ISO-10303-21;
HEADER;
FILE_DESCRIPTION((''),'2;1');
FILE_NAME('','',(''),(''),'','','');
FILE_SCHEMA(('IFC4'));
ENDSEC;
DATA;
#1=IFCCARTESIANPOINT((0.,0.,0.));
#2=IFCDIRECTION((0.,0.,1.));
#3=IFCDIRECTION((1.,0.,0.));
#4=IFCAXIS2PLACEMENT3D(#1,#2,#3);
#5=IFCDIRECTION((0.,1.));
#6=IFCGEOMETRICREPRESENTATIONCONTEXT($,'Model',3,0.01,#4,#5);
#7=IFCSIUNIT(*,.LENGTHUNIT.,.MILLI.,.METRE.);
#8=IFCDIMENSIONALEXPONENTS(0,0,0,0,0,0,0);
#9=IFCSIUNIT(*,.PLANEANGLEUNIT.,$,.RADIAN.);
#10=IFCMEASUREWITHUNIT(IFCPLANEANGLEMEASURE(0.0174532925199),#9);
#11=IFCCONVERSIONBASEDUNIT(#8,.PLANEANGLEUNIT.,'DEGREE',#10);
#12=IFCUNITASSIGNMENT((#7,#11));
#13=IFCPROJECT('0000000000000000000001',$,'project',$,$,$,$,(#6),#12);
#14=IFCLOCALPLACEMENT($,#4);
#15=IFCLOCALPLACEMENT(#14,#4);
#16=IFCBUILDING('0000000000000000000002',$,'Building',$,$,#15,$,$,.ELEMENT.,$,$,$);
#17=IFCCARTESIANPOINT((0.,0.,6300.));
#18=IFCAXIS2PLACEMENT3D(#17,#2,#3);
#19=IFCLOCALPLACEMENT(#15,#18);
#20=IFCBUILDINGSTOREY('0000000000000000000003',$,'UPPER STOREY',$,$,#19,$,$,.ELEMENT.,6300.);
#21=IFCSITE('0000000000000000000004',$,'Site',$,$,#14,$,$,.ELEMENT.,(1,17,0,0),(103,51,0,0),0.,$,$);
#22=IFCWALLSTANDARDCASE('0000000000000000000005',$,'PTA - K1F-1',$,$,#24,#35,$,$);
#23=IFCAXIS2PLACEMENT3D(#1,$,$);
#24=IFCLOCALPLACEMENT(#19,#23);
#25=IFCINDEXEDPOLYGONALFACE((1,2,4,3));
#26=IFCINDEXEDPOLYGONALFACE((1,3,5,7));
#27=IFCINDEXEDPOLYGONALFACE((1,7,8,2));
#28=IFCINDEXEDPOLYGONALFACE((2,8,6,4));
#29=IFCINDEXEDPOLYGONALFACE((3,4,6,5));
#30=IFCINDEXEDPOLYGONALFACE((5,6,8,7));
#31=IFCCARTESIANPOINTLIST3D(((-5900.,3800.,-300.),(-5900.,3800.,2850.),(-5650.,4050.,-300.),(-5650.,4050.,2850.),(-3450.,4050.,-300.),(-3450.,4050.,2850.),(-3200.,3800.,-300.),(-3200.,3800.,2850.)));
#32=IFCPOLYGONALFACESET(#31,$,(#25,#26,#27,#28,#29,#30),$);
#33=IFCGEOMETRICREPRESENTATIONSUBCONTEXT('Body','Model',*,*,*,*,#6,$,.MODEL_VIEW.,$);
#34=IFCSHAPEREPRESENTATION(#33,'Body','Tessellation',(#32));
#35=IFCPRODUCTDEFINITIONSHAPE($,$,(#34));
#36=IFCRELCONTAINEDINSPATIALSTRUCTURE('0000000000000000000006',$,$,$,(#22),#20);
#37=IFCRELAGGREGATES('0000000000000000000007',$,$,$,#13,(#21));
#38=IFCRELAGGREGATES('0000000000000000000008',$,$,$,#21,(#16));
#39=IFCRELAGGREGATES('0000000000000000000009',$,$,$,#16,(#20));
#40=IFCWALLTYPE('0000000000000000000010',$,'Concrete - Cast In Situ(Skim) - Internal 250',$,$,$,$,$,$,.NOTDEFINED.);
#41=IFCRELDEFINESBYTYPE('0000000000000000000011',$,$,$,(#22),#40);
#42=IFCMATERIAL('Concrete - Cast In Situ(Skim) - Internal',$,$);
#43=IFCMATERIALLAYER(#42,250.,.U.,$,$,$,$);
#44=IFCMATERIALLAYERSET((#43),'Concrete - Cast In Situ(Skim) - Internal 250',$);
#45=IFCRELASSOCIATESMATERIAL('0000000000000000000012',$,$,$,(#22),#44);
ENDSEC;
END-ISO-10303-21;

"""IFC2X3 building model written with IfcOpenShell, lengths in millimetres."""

from ifc_helpers import new_model, entity, si_unit, converted_unit, direction, frame, origin_with_axes, place, context, subcontext, project, spatial, polyline, outline, extrude, material, layer, layer_set, layer_usage, type_object, element, save


model = new_model("IFC2X3")

# Units and contexts
model_context = context("Model", 3, precision=0.01, world=origin_with_axes(), true_north=direction((0.0, 1.0)))
body_context = subcontext(model_context, "Body", "Model", "MODEL_VIEW")
ifc_project = project(units=[si_unit("LENGTHUNIT", "METRE", prefix="MILLI"), converted_unit("PLANEANGLEUNIT", "DEGREE", entity("IfcPlaneAngleMeasure", 0.0174532925199), si_unit("PLANEANGLEUNIT", "RADIAN"), dimensions=[0, 0, 0, 0, 0, 0, 0])], contexts=[model_context])

# Site, building, storey
site_placement = place(None, origin_with_axes())
site = spatial("IfcSite", under=ifc_project, at=site_placement, Name="Site", CompositionType="ELEMENT", RefLatitude=(1, 17, 0, 0), RefLongitude=(103, 51, 0, 0), RefElevation=0.0)
building_placement = place(site_placement, origin_with_axes())
building = spatial("IfcBuilding", under=site, at=building_placement, Name="Building", CompositionType="ELEMENT")
storey_placement = place(building_placement, frame((0.0, 0.0, 6300.0), z_axis=(0.0, 0.0, 1.0), x_axis=(1.0, 0.0, 0.0)))
storey = spatial("IfcBuildingStorey", under=building, at=storey_placement, Name="UPPER STOREY", CompositionType="ELEMENT", Elevation=6300.0)

# Shared definitions
ifc_material_1 = material(Name="Concrete - Cast In Situ(Skim) - Internal")

# Shared definitions
ifc_layer_1 = layer(ifc_material_1, 250.0, ventilated="UNKNOWN")
ifc_layer_set_1 = layer_set([ifc_layer_1], Name="Concrete - Cast In Situ(Skim) - Internal 250")
wall_type_1 = type_object("IfcWallType", Name="Concrete - Cast In Situ(Skim) - Internal 250", PredefinedType="NOTDEFINED")

# Wall
ifc_layer_usage_1 = layer_usage(ifc_layer_set_1, "AXIS2", "POSITIVE", -250.0)
wall_1_placement = place(storey_placement, frame((-3200.0, 3800.0, -300.0), z_axis=(0.0, 0.0, 1.0), x_axis=(-1.0, 0.0, 0.0)))
element("IfcWallStandardCase", 1, at=wall_1_placement, inside=storey, type_object=wall_type_1, material=ifc_layer_usage_1, Name="PTA - K1F-1", context=body_context, shape_type="SweptSolid", body=[
    extrude(outline(polyline([(250.0, -250.0), (2450.0, -250.0), (2700.0, 0.0), (0.0, 0.0), (250.0, -250.0)])), origin_with_axes(), (0.0, 0.0, 1.0), 3150.0),
])

save(model, "model.ifc")
